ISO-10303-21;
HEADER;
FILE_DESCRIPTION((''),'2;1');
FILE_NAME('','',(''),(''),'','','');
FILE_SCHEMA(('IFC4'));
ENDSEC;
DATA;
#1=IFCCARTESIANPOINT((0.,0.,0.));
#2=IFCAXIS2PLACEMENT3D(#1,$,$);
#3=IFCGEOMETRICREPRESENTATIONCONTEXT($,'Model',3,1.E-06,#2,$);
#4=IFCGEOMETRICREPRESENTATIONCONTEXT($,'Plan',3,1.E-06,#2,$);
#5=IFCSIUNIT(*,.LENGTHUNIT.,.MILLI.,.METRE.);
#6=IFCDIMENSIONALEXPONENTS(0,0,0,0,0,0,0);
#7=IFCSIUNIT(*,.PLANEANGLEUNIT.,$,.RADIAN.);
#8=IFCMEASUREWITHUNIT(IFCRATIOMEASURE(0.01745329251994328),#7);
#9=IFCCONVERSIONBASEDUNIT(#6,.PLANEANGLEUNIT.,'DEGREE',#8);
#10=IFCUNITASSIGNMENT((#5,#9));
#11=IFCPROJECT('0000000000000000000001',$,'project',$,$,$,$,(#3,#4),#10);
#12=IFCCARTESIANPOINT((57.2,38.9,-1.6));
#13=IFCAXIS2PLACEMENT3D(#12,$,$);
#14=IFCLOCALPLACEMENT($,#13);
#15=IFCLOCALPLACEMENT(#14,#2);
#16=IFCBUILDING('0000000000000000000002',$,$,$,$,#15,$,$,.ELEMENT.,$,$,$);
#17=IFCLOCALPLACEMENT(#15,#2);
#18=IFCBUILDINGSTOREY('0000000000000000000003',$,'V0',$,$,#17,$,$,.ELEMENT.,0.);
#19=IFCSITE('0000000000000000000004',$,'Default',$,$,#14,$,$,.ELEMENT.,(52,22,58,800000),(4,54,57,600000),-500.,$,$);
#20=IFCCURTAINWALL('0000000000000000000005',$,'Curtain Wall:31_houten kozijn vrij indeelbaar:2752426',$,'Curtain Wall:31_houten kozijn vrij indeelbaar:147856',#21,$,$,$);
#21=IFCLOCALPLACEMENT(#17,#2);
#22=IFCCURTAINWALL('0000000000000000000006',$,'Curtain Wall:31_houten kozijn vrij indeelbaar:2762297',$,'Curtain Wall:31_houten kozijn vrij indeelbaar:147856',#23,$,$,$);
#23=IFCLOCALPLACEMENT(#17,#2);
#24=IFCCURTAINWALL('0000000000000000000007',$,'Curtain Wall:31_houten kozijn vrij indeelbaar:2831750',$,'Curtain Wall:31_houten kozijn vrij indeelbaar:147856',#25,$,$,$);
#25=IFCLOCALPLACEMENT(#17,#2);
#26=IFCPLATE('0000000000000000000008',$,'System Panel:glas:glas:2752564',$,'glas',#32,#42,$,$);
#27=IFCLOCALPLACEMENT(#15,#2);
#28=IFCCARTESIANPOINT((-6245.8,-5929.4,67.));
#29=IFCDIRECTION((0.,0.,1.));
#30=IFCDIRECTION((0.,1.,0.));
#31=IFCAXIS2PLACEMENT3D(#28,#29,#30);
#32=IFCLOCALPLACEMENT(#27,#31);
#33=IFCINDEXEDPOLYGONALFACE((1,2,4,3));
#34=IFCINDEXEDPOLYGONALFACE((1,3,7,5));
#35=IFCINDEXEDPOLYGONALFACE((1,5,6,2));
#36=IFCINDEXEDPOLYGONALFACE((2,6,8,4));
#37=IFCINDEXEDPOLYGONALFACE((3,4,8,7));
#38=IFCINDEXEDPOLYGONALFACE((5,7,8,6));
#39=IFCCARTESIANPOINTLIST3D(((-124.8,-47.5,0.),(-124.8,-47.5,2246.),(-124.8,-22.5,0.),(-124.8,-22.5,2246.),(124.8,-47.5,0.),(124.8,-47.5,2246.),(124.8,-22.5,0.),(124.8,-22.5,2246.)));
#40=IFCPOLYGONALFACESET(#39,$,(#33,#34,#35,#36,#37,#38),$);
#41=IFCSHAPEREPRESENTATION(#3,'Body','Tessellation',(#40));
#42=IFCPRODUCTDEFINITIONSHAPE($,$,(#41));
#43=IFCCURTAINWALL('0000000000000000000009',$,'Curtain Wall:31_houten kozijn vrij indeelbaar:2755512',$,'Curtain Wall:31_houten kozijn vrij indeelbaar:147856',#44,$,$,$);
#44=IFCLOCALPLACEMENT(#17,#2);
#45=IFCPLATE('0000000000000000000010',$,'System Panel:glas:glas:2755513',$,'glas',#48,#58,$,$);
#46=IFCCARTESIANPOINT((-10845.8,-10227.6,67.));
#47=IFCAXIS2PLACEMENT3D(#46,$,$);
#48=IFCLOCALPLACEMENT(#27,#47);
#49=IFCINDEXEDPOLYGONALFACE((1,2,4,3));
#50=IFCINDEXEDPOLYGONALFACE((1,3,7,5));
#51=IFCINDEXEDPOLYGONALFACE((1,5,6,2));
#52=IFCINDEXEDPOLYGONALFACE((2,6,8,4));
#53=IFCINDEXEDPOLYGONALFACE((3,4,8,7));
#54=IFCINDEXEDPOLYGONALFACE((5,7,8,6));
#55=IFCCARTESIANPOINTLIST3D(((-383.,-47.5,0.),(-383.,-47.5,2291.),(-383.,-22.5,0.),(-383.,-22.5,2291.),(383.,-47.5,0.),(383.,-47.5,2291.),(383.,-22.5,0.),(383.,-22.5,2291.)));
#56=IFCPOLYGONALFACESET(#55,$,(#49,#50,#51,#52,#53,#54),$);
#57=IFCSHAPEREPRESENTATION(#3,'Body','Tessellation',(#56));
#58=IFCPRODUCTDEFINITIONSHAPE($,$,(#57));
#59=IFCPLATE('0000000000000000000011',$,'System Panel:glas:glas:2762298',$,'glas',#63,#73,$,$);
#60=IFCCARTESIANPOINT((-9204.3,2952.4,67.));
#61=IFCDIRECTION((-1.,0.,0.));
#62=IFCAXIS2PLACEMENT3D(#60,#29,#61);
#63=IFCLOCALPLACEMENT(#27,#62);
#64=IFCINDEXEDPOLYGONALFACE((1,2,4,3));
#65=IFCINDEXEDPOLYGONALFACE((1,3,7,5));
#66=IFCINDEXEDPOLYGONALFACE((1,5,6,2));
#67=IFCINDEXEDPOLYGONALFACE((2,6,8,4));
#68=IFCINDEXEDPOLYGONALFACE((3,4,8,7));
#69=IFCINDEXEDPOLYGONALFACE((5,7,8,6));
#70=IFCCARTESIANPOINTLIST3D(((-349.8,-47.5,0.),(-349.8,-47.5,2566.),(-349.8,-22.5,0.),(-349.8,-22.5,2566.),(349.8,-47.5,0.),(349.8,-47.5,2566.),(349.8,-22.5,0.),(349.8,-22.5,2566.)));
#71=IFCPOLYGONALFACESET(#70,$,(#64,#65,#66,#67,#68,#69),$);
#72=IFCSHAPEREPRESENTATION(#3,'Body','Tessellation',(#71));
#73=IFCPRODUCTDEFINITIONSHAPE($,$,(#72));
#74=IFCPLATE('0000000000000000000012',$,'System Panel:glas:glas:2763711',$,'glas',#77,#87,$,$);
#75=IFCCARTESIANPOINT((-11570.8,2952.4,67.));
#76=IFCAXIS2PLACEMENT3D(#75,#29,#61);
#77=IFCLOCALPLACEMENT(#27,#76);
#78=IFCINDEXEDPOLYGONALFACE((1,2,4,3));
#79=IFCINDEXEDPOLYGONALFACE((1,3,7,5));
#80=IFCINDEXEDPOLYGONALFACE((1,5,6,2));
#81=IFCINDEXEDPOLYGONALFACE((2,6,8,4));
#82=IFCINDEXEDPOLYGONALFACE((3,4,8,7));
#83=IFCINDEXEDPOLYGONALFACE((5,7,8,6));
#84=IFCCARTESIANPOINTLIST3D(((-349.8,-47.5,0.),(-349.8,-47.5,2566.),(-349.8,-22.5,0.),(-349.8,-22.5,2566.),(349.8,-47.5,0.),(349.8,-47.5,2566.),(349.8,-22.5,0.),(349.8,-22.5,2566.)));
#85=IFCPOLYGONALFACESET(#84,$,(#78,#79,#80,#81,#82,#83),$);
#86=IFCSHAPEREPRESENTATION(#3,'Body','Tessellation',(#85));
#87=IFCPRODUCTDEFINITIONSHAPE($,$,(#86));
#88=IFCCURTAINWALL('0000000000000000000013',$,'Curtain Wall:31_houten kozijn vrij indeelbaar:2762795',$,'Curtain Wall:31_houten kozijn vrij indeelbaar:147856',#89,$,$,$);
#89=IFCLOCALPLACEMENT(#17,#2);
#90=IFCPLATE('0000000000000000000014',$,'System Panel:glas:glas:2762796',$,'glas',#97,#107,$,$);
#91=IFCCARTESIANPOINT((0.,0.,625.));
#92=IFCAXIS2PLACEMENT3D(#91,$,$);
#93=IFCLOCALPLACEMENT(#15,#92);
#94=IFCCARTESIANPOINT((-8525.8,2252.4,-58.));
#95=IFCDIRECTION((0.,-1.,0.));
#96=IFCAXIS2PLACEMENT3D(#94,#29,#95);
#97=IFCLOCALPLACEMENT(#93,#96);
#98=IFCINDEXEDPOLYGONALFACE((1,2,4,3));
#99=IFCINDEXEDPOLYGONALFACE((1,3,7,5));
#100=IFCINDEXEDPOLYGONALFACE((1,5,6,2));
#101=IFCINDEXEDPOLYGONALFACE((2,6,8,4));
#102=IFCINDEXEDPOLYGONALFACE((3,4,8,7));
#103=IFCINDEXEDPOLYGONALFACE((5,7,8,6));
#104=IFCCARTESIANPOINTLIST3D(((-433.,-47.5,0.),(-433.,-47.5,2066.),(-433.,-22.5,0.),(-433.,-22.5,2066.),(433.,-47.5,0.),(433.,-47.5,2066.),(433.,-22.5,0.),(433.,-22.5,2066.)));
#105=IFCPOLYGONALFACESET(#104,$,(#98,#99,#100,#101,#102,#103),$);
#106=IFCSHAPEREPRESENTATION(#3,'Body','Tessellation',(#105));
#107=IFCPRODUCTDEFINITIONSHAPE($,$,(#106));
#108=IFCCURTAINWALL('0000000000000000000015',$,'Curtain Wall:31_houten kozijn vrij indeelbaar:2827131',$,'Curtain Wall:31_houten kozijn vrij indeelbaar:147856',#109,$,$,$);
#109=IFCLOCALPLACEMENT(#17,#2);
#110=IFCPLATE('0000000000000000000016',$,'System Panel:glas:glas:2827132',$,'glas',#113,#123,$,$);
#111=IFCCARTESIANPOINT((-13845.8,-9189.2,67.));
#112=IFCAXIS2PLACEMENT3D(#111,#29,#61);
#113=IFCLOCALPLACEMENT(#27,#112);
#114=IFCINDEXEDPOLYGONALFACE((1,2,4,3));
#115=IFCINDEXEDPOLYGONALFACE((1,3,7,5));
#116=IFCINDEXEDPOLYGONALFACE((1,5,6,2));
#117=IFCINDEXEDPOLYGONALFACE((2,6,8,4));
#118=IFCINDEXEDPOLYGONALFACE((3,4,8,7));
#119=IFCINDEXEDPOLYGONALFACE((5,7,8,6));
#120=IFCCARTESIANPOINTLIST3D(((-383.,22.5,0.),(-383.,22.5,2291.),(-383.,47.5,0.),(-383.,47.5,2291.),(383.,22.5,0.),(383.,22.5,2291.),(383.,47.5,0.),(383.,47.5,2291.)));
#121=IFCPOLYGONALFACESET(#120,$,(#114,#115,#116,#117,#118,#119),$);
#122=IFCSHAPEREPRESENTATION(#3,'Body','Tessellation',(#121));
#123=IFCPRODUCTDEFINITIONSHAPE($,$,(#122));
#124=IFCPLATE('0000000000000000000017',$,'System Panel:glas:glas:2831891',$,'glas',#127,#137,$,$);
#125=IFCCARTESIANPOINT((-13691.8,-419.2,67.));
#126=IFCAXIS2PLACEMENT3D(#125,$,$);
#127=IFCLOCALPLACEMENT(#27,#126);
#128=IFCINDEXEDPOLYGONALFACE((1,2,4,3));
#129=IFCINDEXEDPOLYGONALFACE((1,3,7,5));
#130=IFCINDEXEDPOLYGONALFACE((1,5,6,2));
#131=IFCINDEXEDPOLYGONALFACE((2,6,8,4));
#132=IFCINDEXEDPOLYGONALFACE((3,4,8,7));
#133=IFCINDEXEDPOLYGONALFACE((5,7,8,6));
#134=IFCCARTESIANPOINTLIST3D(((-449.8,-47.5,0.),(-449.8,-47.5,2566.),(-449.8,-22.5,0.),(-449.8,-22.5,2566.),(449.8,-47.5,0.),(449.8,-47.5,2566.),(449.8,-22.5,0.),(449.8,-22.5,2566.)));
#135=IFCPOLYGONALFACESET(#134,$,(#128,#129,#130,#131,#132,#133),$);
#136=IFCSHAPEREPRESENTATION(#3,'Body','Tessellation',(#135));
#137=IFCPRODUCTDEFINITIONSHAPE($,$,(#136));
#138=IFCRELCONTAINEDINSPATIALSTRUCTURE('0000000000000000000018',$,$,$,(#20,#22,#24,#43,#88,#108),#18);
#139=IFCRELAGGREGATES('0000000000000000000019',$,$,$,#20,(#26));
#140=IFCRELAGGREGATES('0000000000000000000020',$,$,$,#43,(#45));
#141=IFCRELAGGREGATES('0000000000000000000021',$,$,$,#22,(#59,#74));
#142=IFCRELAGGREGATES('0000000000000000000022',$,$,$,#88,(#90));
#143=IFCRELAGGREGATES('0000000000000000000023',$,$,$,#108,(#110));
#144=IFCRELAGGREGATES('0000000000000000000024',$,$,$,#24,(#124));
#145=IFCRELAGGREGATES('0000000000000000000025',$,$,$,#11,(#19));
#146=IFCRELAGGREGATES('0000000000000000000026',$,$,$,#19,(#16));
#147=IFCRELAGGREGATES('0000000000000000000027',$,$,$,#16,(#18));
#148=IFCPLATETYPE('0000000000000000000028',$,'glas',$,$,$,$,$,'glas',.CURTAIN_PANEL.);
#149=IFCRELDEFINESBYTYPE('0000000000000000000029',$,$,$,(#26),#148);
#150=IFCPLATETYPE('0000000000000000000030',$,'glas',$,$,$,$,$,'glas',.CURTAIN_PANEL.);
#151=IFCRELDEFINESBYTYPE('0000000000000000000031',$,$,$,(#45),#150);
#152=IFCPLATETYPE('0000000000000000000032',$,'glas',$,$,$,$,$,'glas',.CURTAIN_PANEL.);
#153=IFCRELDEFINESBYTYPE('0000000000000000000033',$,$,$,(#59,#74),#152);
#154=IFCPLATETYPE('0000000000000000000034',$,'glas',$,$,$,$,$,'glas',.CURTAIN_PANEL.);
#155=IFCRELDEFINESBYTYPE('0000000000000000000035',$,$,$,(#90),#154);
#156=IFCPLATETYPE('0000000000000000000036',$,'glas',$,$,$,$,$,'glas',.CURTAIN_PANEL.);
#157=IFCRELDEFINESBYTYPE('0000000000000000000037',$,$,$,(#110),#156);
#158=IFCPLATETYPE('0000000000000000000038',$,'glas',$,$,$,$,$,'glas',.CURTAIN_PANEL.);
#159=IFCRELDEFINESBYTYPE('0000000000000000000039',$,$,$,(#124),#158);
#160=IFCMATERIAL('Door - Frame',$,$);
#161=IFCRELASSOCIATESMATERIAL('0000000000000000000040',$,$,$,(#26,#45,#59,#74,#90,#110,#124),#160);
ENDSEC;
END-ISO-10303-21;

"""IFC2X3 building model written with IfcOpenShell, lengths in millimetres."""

from ifc_helpers import new_model, entity, si_unit, converted_unit, frame, origin, origin_2d_with_axis, place, context, project, spatial, rectangle, extrude, source, transform, mapped, material, type_object, type_shapes, element, aggregate, save


model = new_model("IFC2X3")

# Units and contexts
model_context = context("Model", 3, precision=1e-06, world=origin())
plan_context = context("Plan", 3, precision=1e-06, world=origin())
ifc_project = project(units=[si_unit("LENGTHUNIT", "METRE", prefix="MILLI"), converted_unit("PLANEANGLEUNIT", "DEGREE", entity("IfcRatioMeasure", 0.01745329251994328), si_unit("PLANEANGLEUNIT", "RADIAN"), dimensions=[0, 0, 0, 0, 0, 0, 0])], contexts=[model_context, plan_context])

# Site, building, storey
site_placement = place(None, frame((57.2, 38.9, -1.6)))
site = spatial("IfcSite", under=ifc_project, at=site_placement, Name="Default", CompositionType="ELEMENT", RefLatitude=(52, 22, 58, 800000), RefLongitude=(4, 54, 57, 600000), RefElevation=-500.0)
building_placement = place(site_placement, origin())
building = spatial("IfcBuilding", under=site, at=building_placement, CompositionType="ELEMENT")
storey_placement = place(building_placement, origin())
storey = spatial("IfcBuildingStorey", under=building, at=storey_placement, Name="V0", CompositionType="ELEMENT", Elevation=0.0)

# Curtain walls
curtain_wall_1_placement = place(storey_placement, origin())
curtain_wall_1 = element("IfcCurtainWall", 1, at=curtain_wall_1_placement, inside=storey, Name="Curtain Wall:31_houten kozijn vrij indeelbaar:2752426", ObjectType="Curtain Wall:31_houten kozijn vrij indeelbaar:147856")
placement_1 = place(building_placement, frame((0.0, 0.0, 625.0)))
placement_2 = place(building_placement, origin())
curtain_wall_2_placement = place(storey_placement, origin())
curtain_wall_2 = element("IfcCurtainWall", 2, at=curtain_wall_2_placement, inside=storey, Name="Curtain Wall:31_houten kozijn vrij indeelbaar:2762297", ObjectType="Curtain Wall:31_houten kozijn vrij indeelbaar:147856")

# Curtain wall
curtain_wall_3_placement = place(storey_placement, origin())
curtain_wall_3 = element("IfcCurtainWall", 3, at=curtain_wall_3_placement, inside=storey, Name="Curtain Wall:31_houten kozijn vrij indeelbaar:2831750", ObjectType="Curtain Wall:31_houten kozijn vrij indeelbaar:147856")

# Plate
ifc_material_1 = material(Name="Door - Frame")
plate_type_1 = type_object("IfcPlateType", Name="glas", ElementType="glas", PredefinedType="CURTAIN_PANEL")
shared_shape_1 = source(origin(), model_context, "Body", "SweptSolid", [
    extrude(rectangle(XDim=25.0, YDim=249.5, at=origin_2d_with_axis()), frame((0.0, -35.0, 0.0), z_axis=(0.0, 0.0, 1.0), x_axis=(0.0, 1.0, 0.0)), (0.0, 0.0, 1.0), 2246.0),
])
type_shapes(plate_type_1, [shared_shape_1])
plate_1_placement = place(placement_2, frame((-6245.8, -5929.4, 67.0), z_axis=(0.0, 0.0, 1.0), x_axis=(0.0, 1.0, 0.0)))
plate_1 = element("IfcPlate", 4, at=plate_1_placement, type_object=plate_type_1, material=ifc_material_1, Name="System Panel:glas:glas:2752564", ObjectType="glas", context=model_context, shape_type="MappedRepresentation", body=[
    mapped(shared_shape_1, transform((0.0, 0.0, 0.0), scale=1.0)),
])
aggregate(curtain_wall_1, [plate_1])

# Curtain wall, plate
curtain_wall_4_placement = place(storey_placement, origin())
curtain_wall_4 = element("IfcCurtainWall", 5, at=curtain_wall_4_placement, inside=storey, Name="Curtain Wall:31_houten kozijn vrij indeelbaar:2755512", ObjectType="Curtain Wall:31_houten kozijn vrij indeelbaar:147856")
plate_type_2 = type_object("IfcPlateType", Name="glas", ElementType="glas", PredefinedType="CURTAIN_PANEL")
shared_shape_2 = source(origin(), model_context, "Body", "SweptSolid", [
    extrude(rectangle(XDim=25.0, YDim=766.0, at=origin_2d_with_axis()), frame((0.0, -35.0, 0.0), z_axis=(0.0, 0.0, 1.0), x_axis=(0.0, 1.0, 0.0)), (0.0, 0.0, 1.0), 2291.0),
])
type_shapes(plate_type_2, [shared_shape_2])
plate_2_placement = place(placement_2, frame((-10845.8, -10227.6, 67.0)))
plate_2 = element("IfcPlate", 6, at=plate_2_placement, type_object=plate_type_2, material=ifc_material_1, Name="System Panel:glas:glas:2755513", ObjectType="glas", context=model_context, shape_type="MappedRepresentation", body=[
    mapped(shared_shape_2, transform((0.0, 0.0, 0.0), scale=1.0)),
])
aggregate(curtain_wall_4, [plate_2])

# Plates
plate_type_3 = type_object("IfcPlateType", Name="glas", ElementType="glas", PredefinedType="CURTAIN_PANEL")
shared_shape_3 = source(origin(), model_context, "Body", "SweptSolid", [
    extrude(rectangle(XDim=25.0, YDim=699.5, at=origin_2d_with_axis()), frame((0.0, -35.0, 0.0), z_axis=(0.0, 0.0, 1.0), x_axis=(0.0, 1.0, 0.0)), (0.0, 0.0, 1.0), 2566.0),
])
type_shapes(plate_type_3, [shared_shape_3])
plate_3_placement = place(placement_2, frame((-9204.3, 2952.4, 67.0), z_axis=(0.0, 0.0, 1.0), x_axis=(-1.0, 0.0, 0.0)))
plate_3 = element("IfcPlate", 7, at=plate_3_placement, type_object=plate_type_3, material=ifc_material_1, Name="System Panel:glas:glas:2762298", ObjectType="glas", context=model_context, shape_type="MappedRepresentation", body=[
    mapped(shared_shape_3, transform((0.0, 0.0, 0.0), scale=1.0)),
])
plate_4_placement = place(placement_2, frame((-11570.8, 2952.4, 67.0), z_axis=(0.0, 0.0, 1.0), x_axis=(-1.0, 0.0, 0.0)))
plate_4 = element("IfcPlate", 8, at=plate_4_placement, type_object=plate_type_3, material=ifc_material_1, Name="System Panel:glas:glas:2763711", ObjectType="glas", context=model_context, shape_type="MappedRepresentation", body=[
    mapped(shared_shape_3, transform((0.0, 0.0, 0.0), scale=1.0)),
])
aggregate(curtain_wall_2, [plate_3, plate_4])

# Curtain walls, plates
curtain_wall_5_placement = place(storey_placement, origin())
curtain_wall_5 = element("IfcCurtainWall", 9, at=curtain_wall_5_placement, inside=storey, Name="Curtain Wall:31_houten kozijn vrij indeelbaar:2762795", ObjectType="Curtain Wall:31_houten kozijn vrij indeelbaar:147856")
plate_type_4 = type_object("IfcPlateType", Name="glas", ElementType="glas", PredefinedType="CURTAIN_PANEL")
shared_shape_4 = source(origin(), model_context, "Body", "SweptSolid", [
    extrude(rectangle(XDim=25.0, YDim=866.0, at=origin_2d_with_axis()), frame((0.0, -35.0, 0.0), z_axis=(0.0, 0.0, 1.0), x_axis=(0.0, 1.0, 0.0)), (0.0, 0.0, 1.0), 2066.0),
])
type_shapes(plate_type_4, [shared_shape_4])
plate_5_placement = place(placement_1, frame((-8525.8, 2252.4, -58.0), z_axis=(0.0, 0.0, 1.0), x_axis=(0.0, -1.0, 0.0)))
plate_5 = element("IfcPlate", 10, at=plate_5_placement, type_object=plate_type_4, material=ifc_material_1, Name="System Panel:glas:glas:2762796", ObjectType="glas", context=model_context, shape_type="MappedRepresentation", body=[
    mapped(shared_shape_4, transform((0.0, 0.0, 0.0), scale=1.0)),
])
aggregate(curtain_wall_5, [plate_5])
curtain_wall_6_placement = place(storey_placement, origin())
curtain_wall_6 = element("IfcCurtainWall", 11, at=curtain_wall_6_placement, inside=storey, Name="Curtain Wall:31_houten kozijn vrij indeelbaar:2827131", ObjectType="Curtain Wall:31_houten kozijn vrij indeelbaar:147856")
plate_type_5 = type_object("IfcPlateType", Name="glas", ElementType="glas", PredefinedType="CURTAIN_PANEL")
shared_shape_5 = source(origin(), model_context, "Body", "SweptSolid", [
    extrude(rectangle(XDim=25.0, YDim=766.0, at=origin_2d_with_axis()), frame((0.0, 35.0, 0.0), z_axis=(0.0, 0.0, 1.0), x_axis=(0.0, 1.0, 0.0)), (0.0, 0.0, 1.0), 2291.0),
])
type_shapes(plate_type_5, [shared_shape_5])
plate_6_placement = place(placement_2, frame((-13845.8, -9189.2, 67.0), z_axis=(0.0, 0.0, 1.0), x_axis=(-1.0, 0.0, 0.0)))
plate_6 = element("IfcPlate", 12, at=plate_6_placement, type_object=plate_type_5, material=ifc_material_1, Name="System Panel:glas:glas:2827132", ObjectType="glas", context=model_context, shape_type="MappedRepresentation", body=[
    mapped(shared_shape_5, transform((0.0, 0.0, 0.0), scale=1.0)),
])
aggregate(curtain_wall_6, [plate_6])

# Plate
plate_type_6 = type_object("IfcPlateType", Name="glas", ElementType="glas", PredefinedType="CURTAIN_PANEL")
shared_shape_6 = source(origin(), model_context, "Body", "SweptSolid", [
    extrude(rectangle(XDim=25.0, YDim=899.5, at=origin_2d_with_axis()), frame((0.0, -35.0, 0.0), z_axis=(0.0, 0.0, 1.0), x_axis=(0.0, 1.0, 0.0)), (0.0, 0.0, 1.0), 2566.0),
])
type_shapes(plate_type_6, [shared_shape_6])
plate_7_placement = place(placement_2, frame((-13691.8, -419.2, 67.0)))
plate_7 = element("IfcPlate", 13, at=plate_7_placement, type_object=plate_type_6, material=ifc_material_1, Name="System Panel:glas:glas:2831891", ObjectType="glas", context=model_context, shape_type="MappedRepresentation", body=[
    mapped(shared_shape_6, transform((0.0, 0.0, 0.0), scale=1.0)),
])
aggregate(curtain_wall_3, [plate_7])

save(model, "model.ifc")
